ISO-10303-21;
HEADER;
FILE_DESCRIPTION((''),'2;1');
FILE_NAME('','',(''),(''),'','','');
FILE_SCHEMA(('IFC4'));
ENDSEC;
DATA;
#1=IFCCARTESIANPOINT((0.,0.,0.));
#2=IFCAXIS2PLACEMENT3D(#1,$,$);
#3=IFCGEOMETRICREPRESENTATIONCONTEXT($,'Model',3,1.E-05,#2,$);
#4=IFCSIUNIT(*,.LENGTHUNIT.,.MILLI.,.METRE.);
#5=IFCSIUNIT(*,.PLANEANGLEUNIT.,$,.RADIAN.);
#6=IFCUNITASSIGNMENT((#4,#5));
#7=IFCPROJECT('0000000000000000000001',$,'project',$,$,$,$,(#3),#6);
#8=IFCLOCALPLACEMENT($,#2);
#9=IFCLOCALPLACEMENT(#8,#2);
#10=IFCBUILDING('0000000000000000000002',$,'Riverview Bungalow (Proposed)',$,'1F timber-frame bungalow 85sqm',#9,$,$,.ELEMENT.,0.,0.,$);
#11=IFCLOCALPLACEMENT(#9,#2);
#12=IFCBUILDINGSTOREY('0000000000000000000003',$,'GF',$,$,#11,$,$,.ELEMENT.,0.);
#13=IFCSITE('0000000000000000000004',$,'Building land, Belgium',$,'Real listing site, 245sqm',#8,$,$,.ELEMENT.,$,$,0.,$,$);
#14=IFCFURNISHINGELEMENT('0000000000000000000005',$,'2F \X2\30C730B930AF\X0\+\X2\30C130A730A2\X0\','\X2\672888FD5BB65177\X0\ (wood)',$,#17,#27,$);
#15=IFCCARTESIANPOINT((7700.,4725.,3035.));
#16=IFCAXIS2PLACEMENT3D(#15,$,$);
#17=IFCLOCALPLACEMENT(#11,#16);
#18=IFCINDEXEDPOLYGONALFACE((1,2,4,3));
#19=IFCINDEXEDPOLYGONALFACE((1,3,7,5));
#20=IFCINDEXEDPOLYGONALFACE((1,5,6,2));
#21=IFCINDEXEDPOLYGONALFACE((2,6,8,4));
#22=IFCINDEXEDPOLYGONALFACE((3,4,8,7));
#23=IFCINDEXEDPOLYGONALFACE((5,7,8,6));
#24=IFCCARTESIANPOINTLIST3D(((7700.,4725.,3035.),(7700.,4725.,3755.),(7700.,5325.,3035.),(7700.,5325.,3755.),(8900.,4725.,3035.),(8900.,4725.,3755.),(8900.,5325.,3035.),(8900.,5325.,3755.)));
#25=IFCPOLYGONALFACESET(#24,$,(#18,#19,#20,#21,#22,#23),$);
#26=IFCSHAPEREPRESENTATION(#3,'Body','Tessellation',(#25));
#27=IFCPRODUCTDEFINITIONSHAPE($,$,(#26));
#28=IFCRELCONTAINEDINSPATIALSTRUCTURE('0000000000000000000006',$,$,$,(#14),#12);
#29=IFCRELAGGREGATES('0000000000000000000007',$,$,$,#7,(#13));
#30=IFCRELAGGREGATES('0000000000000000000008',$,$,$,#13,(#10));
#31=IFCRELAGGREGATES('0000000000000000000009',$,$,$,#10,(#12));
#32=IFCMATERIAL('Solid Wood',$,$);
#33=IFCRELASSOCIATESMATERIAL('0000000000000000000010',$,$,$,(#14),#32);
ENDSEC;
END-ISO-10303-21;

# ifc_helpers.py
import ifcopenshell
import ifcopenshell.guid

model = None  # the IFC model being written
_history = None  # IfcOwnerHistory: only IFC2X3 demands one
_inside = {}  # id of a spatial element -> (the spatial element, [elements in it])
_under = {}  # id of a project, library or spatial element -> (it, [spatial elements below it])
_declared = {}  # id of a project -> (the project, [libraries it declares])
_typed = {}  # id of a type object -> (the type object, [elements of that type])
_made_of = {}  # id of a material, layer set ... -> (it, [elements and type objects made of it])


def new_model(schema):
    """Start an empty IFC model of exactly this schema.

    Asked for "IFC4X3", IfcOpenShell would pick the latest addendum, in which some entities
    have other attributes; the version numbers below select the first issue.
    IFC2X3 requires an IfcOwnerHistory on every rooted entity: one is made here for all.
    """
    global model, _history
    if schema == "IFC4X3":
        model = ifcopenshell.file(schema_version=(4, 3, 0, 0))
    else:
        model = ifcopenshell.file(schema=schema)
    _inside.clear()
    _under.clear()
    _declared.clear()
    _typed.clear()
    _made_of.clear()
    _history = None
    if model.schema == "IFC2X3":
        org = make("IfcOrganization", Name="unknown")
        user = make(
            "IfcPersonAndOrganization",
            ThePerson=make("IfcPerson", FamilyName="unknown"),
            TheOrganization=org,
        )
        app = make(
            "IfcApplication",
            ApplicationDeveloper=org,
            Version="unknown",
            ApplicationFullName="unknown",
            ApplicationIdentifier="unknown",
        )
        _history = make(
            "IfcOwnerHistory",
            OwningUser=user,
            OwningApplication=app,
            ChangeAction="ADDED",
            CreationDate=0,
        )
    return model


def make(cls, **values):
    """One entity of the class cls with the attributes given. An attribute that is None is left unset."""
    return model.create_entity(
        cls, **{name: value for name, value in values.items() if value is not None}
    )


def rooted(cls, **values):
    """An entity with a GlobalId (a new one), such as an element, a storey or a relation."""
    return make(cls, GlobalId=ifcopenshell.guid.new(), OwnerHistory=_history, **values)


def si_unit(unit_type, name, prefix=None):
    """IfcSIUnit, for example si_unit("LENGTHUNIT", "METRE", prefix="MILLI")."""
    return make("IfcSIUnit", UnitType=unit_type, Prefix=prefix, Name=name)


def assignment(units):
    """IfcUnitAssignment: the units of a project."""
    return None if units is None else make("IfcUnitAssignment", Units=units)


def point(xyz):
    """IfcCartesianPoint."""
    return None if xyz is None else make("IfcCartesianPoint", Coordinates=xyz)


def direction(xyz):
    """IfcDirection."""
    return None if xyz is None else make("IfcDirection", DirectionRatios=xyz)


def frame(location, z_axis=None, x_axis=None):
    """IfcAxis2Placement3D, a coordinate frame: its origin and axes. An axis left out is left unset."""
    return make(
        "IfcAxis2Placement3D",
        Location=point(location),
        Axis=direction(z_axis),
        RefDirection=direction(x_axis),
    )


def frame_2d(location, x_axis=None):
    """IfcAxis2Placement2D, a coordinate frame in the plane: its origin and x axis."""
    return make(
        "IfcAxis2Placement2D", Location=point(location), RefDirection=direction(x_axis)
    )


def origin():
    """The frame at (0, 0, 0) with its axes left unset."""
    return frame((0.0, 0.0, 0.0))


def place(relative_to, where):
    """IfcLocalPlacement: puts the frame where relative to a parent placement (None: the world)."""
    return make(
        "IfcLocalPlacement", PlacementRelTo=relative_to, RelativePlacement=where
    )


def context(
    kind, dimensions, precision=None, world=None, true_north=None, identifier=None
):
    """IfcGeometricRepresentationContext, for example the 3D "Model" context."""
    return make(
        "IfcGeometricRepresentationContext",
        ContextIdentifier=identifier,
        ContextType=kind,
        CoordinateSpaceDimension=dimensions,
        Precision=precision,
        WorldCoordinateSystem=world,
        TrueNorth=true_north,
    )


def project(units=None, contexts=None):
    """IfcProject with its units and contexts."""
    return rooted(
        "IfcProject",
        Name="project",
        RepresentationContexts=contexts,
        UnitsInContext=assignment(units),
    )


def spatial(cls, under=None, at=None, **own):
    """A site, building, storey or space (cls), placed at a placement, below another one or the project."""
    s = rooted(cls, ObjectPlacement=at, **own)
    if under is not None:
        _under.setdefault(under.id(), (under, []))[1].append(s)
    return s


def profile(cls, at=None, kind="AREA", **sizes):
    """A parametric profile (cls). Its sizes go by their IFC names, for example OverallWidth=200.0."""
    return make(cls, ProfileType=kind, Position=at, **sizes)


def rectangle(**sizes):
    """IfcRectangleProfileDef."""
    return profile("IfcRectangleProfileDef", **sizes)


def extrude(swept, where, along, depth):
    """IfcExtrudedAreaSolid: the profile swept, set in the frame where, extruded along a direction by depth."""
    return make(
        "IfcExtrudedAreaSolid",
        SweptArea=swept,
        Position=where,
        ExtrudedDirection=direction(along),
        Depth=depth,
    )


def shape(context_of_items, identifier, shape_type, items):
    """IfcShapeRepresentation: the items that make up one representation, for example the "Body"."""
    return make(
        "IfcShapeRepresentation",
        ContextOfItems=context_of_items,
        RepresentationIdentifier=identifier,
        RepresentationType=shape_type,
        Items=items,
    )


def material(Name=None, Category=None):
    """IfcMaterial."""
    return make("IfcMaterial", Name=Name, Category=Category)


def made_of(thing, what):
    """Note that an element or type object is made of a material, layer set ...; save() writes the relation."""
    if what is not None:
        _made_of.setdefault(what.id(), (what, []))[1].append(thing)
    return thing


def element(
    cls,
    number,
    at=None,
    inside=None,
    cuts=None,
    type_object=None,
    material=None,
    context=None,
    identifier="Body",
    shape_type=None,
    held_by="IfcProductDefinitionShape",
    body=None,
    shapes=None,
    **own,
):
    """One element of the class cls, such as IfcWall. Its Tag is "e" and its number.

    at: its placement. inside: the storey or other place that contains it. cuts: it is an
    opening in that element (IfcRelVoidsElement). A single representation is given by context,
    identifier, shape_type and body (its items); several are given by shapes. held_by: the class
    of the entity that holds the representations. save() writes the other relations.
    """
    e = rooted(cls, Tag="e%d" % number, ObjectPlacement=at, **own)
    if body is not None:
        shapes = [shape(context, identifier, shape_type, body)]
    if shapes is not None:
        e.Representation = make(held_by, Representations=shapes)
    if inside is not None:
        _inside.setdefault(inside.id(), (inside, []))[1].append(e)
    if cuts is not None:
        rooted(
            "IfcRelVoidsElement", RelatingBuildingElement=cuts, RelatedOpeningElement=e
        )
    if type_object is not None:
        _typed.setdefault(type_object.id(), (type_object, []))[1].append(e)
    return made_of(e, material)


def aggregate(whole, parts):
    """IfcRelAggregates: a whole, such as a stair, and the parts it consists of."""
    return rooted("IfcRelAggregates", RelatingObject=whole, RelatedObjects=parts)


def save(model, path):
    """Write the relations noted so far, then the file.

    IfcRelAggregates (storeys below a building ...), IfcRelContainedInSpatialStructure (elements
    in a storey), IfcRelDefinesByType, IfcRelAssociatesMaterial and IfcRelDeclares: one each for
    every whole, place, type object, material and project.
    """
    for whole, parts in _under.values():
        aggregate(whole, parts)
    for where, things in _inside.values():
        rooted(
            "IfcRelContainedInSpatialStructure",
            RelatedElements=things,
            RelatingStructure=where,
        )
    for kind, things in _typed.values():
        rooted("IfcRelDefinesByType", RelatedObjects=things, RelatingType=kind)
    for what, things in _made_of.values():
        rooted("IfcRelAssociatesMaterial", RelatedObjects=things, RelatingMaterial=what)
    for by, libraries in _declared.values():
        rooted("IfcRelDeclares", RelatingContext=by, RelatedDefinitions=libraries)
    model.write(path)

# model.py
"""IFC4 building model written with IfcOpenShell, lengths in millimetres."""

from ifc_helpers import new_model, si_unit, frame, frame_2d, origin, place, context, project, spatial, rectangle, extrude, material, element, save


model = new_model("IFC4")

# Units and contexts
model_context = context("Model", 3, precision=1e-05, world=origin())
ifc_project = project(units=[si_unit("LENGTHUNIT", "METRE", prefix="MILLI"), si_unit("PLANEANGLEUNIT", "RADIAN")], contexts=[model_context])

# Site, building, storey
site_placement = place(None, origin())
site = spatial("IfcSite", under=ifc_project, at=site_placement, Name="Building land, Belgium", ObjectType="Real listing site, 245sqm", CompositionType="ELEMENT", RefElevation=0.0)
building_placement = place(site_placement, origin())
building = spatial("IfcBuilding", under=site, at=building_placement, Name="Riverview Bungalow (Proposed)", ObjectType="1F timber-frame bungalow 85sqm", CompositionType="ELEMENT", ElevationOfRefHeight=0.0, ElevationOfTerrain=0.0)
storey_placement = place(building_placement, origin())
storey = spatial("IfcBuildingStorey", under=building, at=storey_placement, Name="GF", CompositionType="ELEMENT", Elevation=0.0)

# Shared definitions
ifc_material_1 = material(Name="Solid Wood")

# Furnishing element
furnishing_1_placement = place(storey_placement, frame((7700.0, 4725.0, 3035.0)))
element("IfcFurnishingElement", 1, at=furnishing_1_placement, inside=storey, material=ifc_material_1, Name="2F デスク+チェア", Description="木製家具 (wood)", context=model_context, shape_type="SweptSolid", body=[
    extrude(rectangle(XDim=1200.0, YDim=600.0, at=frame_2d((600.0, 300.0))), frame((7700.0, 4725.0, 3035.0)), (0.0, 0.0, 1.0), 720.0),
])

save(model, "model.ifc")
